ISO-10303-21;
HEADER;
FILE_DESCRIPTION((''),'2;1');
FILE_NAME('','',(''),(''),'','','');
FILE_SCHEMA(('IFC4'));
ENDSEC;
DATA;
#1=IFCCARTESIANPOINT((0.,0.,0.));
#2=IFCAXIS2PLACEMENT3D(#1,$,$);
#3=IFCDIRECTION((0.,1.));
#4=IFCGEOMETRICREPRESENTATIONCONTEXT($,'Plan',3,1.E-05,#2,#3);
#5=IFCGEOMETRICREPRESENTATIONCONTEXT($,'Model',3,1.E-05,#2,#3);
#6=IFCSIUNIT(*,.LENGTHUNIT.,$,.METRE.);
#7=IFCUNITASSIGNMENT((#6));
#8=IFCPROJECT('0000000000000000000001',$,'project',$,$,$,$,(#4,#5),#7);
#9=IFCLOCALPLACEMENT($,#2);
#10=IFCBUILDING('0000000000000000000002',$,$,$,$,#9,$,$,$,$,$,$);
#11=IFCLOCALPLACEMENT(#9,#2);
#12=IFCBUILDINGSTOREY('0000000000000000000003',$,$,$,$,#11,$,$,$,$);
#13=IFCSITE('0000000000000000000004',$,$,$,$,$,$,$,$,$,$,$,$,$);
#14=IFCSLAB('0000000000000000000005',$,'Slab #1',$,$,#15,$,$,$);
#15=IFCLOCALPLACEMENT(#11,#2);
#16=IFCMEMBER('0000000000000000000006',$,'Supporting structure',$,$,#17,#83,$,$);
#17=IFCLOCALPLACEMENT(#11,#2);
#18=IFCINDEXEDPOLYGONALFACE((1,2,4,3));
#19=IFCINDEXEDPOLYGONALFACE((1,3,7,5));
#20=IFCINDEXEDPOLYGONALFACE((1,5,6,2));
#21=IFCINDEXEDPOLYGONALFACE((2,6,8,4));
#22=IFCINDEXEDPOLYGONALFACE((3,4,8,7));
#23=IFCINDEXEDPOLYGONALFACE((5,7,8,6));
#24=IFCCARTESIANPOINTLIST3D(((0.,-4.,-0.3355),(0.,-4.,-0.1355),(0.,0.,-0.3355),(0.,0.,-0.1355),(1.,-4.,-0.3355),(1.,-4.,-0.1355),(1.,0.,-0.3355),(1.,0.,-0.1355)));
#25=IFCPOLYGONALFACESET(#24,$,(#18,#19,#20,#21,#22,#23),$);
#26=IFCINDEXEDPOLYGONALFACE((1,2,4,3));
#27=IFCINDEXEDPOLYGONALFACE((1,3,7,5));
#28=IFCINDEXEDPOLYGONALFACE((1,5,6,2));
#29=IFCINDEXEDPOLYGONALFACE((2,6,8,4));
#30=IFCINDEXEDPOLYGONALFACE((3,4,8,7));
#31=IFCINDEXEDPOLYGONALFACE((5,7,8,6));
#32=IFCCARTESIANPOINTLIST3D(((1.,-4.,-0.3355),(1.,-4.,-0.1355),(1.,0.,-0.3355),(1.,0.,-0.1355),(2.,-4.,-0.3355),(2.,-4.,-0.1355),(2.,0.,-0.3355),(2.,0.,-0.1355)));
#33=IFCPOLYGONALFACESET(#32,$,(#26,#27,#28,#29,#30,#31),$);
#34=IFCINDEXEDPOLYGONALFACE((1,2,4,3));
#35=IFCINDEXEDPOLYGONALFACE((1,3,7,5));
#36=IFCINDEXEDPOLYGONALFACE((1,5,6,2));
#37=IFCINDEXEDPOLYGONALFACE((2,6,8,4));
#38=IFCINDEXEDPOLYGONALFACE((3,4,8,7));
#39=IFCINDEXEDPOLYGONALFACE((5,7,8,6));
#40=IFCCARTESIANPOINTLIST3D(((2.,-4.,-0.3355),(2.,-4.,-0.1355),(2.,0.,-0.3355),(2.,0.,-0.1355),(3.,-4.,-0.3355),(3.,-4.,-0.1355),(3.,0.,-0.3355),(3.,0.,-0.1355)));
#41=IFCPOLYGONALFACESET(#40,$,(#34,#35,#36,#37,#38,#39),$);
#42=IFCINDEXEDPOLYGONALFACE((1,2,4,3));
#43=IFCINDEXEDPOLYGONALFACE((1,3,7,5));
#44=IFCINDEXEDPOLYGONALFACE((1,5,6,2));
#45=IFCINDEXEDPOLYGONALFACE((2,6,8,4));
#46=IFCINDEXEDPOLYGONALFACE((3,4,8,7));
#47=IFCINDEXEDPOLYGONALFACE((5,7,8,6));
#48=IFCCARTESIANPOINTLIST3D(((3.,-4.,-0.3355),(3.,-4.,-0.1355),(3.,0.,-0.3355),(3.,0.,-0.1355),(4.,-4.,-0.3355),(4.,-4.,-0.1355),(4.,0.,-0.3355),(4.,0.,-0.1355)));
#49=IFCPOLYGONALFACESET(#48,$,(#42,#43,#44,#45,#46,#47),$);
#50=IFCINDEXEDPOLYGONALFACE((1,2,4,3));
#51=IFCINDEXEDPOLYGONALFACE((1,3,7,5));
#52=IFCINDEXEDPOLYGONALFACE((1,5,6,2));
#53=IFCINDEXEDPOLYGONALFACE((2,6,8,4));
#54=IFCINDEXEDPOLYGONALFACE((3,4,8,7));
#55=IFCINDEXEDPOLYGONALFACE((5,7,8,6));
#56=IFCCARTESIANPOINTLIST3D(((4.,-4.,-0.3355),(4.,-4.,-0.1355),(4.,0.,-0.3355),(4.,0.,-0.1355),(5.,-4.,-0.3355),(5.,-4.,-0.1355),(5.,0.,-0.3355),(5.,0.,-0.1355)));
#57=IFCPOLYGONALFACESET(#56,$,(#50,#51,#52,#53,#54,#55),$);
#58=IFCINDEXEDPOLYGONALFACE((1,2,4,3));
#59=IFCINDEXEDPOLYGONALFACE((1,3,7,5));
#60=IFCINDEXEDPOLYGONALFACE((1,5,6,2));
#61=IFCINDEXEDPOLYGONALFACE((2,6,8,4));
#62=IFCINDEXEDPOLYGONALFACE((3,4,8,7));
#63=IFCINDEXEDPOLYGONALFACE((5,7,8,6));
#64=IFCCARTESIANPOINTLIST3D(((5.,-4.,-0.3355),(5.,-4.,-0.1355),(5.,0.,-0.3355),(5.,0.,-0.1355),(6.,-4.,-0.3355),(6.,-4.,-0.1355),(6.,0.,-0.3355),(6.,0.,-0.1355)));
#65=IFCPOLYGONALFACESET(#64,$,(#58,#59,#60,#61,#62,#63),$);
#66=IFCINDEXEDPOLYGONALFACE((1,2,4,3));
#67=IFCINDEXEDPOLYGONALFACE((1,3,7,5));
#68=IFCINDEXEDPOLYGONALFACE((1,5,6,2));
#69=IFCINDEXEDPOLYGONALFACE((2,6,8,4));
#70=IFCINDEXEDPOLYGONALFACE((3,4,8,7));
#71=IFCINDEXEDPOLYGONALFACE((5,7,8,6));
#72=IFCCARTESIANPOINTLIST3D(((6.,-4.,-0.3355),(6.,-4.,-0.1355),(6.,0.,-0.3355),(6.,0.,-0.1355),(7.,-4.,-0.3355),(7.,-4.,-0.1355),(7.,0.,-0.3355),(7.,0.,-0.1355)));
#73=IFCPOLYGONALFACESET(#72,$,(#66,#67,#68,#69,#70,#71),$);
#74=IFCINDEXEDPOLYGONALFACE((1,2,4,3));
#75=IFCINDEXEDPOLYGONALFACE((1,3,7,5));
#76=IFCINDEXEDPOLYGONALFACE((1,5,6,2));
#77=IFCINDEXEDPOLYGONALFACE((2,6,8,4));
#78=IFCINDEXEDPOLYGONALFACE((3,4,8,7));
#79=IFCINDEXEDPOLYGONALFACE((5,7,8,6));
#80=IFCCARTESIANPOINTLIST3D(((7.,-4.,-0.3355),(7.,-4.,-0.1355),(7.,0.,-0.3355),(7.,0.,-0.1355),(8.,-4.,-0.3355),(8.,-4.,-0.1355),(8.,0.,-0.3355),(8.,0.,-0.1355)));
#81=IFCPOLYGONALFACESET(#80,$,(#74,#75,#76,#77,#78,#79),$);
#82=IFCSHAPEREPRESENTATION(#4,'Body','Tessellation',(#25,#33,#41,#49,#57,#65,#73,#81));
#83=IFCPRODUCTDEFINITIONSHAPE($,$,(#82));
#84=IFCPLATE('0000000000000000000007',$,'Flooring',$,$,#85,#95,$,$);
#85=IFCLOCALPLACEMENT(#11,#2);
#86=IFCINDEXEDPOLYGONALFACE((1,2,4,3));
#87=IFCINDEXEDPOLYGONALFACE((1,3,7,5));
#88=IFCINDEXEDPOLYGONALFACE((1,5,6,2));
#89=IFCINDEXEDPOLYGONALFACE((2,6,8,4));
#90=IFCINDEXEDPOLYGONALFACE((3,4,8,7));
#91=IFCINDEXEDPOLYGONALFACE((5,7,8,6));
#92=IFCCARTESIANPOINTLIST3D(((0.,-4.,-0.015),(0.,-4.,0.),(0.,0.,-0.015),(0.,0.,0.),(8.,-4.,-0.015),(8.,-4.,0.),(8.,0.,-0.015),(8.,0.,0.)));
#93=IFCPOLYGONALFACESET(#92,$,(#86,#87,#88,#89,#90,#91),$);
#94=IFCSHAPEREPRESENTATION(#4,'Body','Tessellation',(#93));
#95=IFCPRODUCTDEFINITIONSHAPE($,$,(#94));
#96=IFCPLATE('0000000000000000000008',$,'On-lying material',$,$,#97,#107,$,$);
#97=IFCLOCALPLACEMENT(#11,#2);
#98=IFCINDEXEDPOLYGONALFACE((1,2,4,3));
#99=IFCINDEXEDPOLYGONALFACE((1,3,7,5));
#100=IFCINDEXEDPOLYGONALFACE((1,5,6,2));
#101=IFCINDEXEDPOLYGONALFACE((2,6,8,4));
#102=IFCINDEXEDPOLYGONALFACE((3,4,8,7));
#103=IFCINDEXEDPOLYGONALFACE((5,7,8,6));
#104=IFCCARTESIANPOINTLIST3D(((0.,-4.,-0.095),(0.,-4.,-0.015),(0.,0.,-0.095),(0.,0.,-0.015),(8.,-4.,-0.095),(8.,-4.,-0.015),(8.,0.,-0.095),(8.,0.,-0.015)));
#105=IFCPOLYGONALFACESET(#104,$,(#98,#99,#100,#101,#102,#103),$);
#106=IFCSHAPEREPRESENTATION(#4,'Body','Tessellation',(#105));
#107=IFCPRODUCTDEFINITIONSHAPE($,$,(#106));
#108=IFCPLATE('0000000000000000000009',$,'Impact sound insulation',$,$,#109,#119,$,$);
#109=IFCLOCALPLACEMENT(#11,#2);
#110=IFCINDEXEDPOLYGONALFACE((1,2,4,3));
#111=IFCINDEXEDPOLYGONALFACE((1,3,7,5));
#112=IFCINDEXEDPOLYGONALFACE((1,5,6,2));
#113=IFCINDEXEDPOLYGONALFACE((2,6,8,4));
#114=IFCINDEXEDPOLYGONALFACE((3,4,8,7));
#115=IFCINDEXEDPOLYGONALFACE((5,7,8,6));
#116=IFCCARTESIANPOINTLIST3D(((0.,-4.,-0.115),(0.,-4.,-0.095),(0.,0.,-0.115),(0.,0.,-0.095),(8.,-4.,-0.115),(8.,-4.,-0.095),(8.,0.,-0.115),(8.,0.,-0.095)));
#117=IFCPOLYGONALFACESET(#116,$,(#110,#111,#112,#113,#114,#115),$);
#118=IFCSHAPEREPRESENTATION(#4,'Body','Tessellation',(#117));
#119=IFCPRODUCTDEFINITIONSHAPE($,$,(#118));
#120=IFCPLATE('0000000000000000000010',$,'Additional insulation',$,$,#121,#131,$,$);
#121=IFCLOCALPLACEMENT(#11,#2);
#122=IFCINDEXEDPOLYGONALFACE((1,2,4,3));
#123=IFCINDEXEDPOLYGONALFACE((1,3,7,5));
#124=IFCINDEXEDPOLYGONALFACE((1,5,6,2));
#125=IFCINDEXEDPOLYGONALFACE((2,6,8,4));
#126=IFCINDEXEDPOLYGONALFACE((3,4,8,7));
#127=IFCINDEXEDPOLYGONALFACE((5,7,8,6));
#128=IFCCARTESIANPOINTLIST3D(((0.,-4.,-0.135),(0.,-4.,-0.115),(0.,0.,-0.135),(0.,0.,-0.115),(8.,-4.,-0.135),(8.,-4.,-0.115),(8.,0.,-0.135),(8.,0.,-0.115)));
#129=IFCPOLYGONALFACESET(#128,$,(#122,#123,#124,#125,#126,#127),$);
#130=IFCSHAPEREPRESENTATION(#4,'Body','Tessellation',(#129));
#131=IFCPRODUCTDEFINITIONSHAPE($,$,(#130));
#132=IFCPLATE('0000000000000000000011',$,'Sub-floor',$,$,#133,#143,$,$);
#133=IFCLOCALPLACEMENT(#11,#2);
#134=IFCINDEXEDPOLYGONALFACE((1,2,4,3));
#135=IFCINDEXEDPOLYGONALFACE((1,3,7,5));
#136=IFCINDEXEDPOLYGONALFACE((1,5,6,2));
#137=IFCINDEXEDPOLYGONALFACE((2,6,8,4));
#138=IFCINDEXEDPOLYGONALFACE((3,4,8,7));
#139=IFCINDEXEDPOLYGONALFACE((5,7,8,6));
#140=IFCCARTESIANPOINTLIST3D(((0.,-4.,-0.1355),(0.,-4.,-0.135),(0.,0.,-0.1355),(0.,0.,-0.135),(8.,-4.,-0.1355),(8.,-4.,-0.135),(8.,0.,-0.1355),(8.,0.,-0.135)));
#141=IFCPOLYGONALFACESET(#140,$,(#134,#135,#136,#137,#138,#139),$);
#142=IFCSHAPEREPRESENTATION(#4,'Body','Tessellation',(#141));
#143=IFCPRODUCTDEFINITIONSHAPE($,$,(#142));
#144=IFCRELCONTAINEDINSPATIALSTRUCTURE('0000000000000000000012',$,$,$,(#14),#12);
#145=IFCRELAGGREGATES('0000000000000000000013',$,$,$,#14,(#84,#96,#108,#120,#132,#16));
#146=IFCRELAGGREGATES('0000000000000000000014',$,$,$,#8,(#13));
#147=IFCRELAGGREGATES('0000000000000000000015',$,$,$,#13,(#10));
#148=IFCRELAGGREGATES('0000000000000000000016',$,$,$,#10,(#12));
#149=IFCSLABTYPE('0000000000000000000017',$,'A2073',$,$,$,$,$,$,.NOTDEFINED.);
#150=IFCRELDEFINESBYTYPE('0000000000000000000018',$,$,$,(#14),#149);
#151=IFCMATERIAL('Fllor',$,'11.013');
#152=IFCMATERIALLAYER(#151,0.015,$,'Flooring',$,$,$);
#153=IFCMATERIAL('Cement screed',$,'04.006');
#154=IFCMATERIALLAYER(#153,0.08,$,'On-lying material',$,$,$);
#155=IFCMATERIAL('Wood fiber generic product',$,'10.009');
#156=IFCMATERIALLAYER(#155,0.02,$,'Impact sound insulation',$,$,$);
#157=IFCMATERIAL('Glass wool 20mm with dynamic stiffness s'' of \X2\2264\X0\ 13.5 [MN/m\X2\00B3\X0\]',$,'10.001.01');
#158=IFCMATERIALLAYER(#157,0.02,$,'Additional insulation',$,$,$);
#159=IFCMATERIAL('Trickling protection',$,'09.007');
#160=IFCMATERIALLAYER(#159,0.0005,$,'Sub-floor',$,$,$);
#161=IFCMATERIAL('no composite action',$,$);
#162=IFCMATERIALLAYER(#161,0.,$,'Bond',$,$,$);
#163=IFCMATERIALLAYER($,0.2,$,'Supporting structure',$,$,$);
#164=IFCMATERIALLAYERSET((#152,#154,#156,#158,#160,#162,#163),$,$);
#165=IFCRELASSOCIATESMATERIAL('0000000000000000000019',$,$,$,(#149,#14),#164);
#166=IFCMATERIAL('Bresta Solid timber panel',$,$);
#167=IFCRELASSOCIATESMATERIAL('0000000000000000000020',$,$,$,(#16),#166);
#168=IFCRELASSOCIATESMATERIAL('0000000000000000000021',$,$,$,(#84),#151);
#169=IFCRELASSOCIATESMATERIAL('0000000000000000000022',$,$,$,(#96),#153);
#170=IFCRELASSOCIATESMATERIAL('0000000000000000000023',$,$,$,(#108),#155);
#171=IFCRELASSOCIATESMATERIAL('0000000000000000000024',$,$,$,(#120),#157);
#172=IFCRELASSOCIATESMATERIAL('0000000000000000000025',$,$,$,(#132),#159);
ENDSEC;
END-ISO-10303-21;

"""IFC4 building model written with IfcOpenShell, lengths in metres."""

from ifc_helpers import new_model, si_unit, direction, frame, frame_2d, origin, origin_with_axes, place, context, project, spatial, rectangle, extrude, material, layer, layer_set, type_object, element, aggregate, save


model = new_model("IFC4")

# Units and contexts
plan_context = context("Plan", 3, precision=1e-05, world=origin(), true_north=direction((0.0, 1.0)))
model_context = context("Model", 3, precision=1e-05, world=origin(), true_north=direction((0.0, 1.0)))
ifc_project = project(units=[si_unit("LENGTHUNIT", "METRE")], contexts=[plan_context, model_context])

# Site, building, storey
site = spatial("IfcSite", under=ifc_project)
building_placement = place(None, origin())
building = spatial("IfcBuilding", under=site, at=building_placement)
storey_placement = place(building_placement, origin())
storey = spatial("IfcBuildingStorey", under=building, at=storey_placement)

# Slab, member, plates
ifc_material_1 = material(Name="Fllor", Category="11.013")
ifc_layer_1 = layer(ifc_material_1, 0.015, Name="Flooring")
ifc_material_2 = material(Name="Cement screed", Category="04.006")
ifc_layer_2 = layer(ifc_material_2, 0.08, Name="On-lying material")
ifc_material_3 = material(Name="Wood fiber generic product", Category="10.009")
ifc_layer_3 = layer(ifc_material_3, 0.02, Name="Impact sound insulation")
ifc_material_4 = material(Name="Glass wool 20mm with dynamic stiffness s' of ≤ 13.5 [MN/m³]", Category="10.001.01")
ifc_layer_4 = layer(ifc_material_4, 0.02, Name="Additional insulation")
ifc_material_5 = material(Name="Trickling protection", Category="09.007")
ifc_layer_5 = layer(ifc_material_5, 0.0005, Name="Sub-floor")
ifc_material_6 = material(Name="no composite action")
ifc_layer_6 = layer(ifc_material_6, 0.0, Name="Bond")
ifc_layer_7 = layer(None, 0.2, Name="Supporting structure")
ifc_layer_set = layer_set([ifc_layer_1, ifc_layer_2, ifc_layer_3, ifc_layer_4, ifc_layer_5, ifc_layer_6, ifc_layer_7])
slab_type = type_object("IfcSlabType", Name="A2073", PredefinedType="NOTDEFINED", material=ifc_layer_set)
slab_placement = place(None, frame((0.0, 0.0, 0.0), z_axis=(0.0, 0.0, -1.0), x_axis=(1.0, 0.0, 0.0)))
slab = element("IfcSlab", 1, at=slab_placement, inside=storey, type_object=slab_type, material=ifc_layer_set, Name="Slab #1")
ifc_material_7 = material(Name="Bresta Solid timber panel")
member_placement = place(slab_placement, origin())
member = element("IfcMember", 2, at=member_placement, material=ifc_material_7, Name="Supporting structure", context=plan_context, shape_type="SweptSolid", body=[
    extrude(rectangle(XDim=1.0, YDim=0.2, at=frame_2d((0.5, 0.1), x_axis=(1.0, 0.0))), frame((0.0, 4.0, 0.1355), z_axis=(0.0, -1.0, 0.0), x_axis=(1.0, 0.0, 0.0)), (0.0, 0.0, 1.0), 4.0),
    extrude(rectangle(XDim=1.0, YDim=0.2, at=frame_2d((0.5, 0.1), x_axis=(1.0, 0.0))), frame((1.0, 4.0, 0.1355), z_axis=(0.0, -1.0, 0.0), x_axis=(1.0, 0.0, 0.0)), (0.0, 0.0, 1.0), 4.0),
    extrude(rectangle(XDim=1.0, YDim=0.2, at=frame_2d((0.5, 0.1), x_axis=(1.0, 0.0))), frame((2.0, 4.0, 0.1355), z_axis=(0.0, -1.0, 0.0), x_axis=(1.0, 0.0, 0.0)), (0.0, 0.0, 1.0), 4.0),
    extrude(rectangle(XDim=1.0, YDim=0.2, at=frame_2d((0.5, 0.1), x_axis=(1.0, 0.0))), frame((3.0, 4.0, 0.1355), z_axis=(0.0, -1.0, 0.0), x_axis=(1.0, 0.0, 0.0)), (0.0, 0.0, 1.0), 4.0),
    extrude(rectangle(XDim=1.0, YDim=0.2, at=frame_2d((0.5, 0.1), x_axis=(1.0, 0.0))), frame((4.0, 4.0, 0.1355), z_axis=(0.0, -1.0, 0.0), x_axis=(1.0, 0.0, 0.0)), (0.0, 0.0, 1.0), 4.0),
    extrude(rectangle(XDim=1.0, YDim=0.2, at=frame_2d((0.5, 0.1), x_axis=(1.0, 0.0))), frame((5.0, 4.0, 0.1355), z_axis=(0.0, -1.0, 0.0), x_axis=(1.0, 0.0, 0.0)), (0.0, 0.0, 1.0), 4.0),
    extrude(rectangle(XDim=1.0, YDim=0.2, at=frame_2d((0.5, 0.1), x_axis=(1.0, 0.0))), frame((6.0, 4.0, 0.1355), z_axis=(0.0, -1.0, 0.0), x_axis=(1.0, 0.0, 0.0)), (0.0, 0.0, 1.0), 4.0),
    extrude(rectangle(XDim=1.0, YDim=0.2, at=frame_2d((0.5, 0.1), x_axis=(1.0, 0.0))), frame((7.0, 4.0, 0.1355), z_axis=(0.0, -1.0, 0.0), x_axis=(1.0, 0.0, 0.0)), (0.0, 0.0, 1.0), 4.0),
])
plate_1_placement = place(slab_placement, origin())
plate_1 = element("IfcPlate", 3, at=plate_1_placement, material=ifc_material_1, Name="Flooring", context=plan_context, shape_type="SweptSolid", body=[
    extrude(rectangle(XDim=8.0, YDim=4.0, at=frame_2d((4.0, 2.0), x_axis=(1.0, 0.0))), origin_with_axes(), (0.0, 0.0, 1.0), 0.015),
])
plate_2_placement = place(slab_placement, origin())
plate_2 = element("IfcPlate", 4, at=plate_2_placement, material=ifc_material_2, Name="On-lying material", context=plan_context, shape_type="SweptSolid", body=[
    extrude(rectangle(XDim=8.0, YDim=4.0, at=frame_2d((4.0, 2.0), x_axis=(1.0, 0.0))), frame((0.0, 0.0, 0.015), z_axis=(0.0, 0.0, 1.0), x_axis=(1.0, 0.0, 0.0)), (0.0, 0.0, 1.0), 0.08),
])
plate_3_placement = place(slab_placement, origin())
plate_3 = element("IfcPlate", 5, at=plate_3_placement, material=ifc_material_3, Name="Impact sound insulation", context=plan_context, shape_type="SweptSolid", body=[
    extrude(rectangle(XDim=8.0, YDim=4.0, at=frame_2d((4.0, 2.0), x_axis=(1.0, 0.0))), frame((0.0, 0.0, 0.095), z_axis=(0.0, 0.0, 1.0), x_axis=(1.0, 0.0, 0.0)), (0.0, 0.0, 1.0), 0.02),
])
plate_4_placement = place(slab_placement, origin())
plate_4 = element("IfcPlate", 6, at=plate_4_placement, material=ifc_material_4, Name="Additional insulation", context=plan_context, shape_type="SweptSolid", body=[
    extrude(rectangle(XDim=8.0, YDim=4.0, at=frame_2d((4.0, 2.0), x_axis=(1.0, 0.0))), frame((0.0, 0.0, 0.115), z_axis=(0.0, 0.0, 1.0), x_axis=(1.0, 0.0, 0.0)), (0.0, 0.0, 1.0), 0.02),
])
plate_5_placement = place(slab_placement, origin())
plate_5 = element("IfcPlate", 7, at=plate_5_placement, material=ifc_material_5, Name="Sub-floor", context=plan_context, shape_type="SweptSolid", body=[
    extrude(rectangle(XDim=8.0, YDim=4.0, at=frame_2d((4.0, 2.0), x_axis=(1.0, 0.0))), frame((0.0, 0.0, 0.135), z_axis=(0.0, 0.0, 1.0), x_axis=(1.0, 0.0, 0.0)), (0.0, 0.0, 1.0), 0.0005),
])
aggregate(slab, [plate_1, plate_2, plate_3, plate_4, plate_5, member])

save(model, "model.ifc")
